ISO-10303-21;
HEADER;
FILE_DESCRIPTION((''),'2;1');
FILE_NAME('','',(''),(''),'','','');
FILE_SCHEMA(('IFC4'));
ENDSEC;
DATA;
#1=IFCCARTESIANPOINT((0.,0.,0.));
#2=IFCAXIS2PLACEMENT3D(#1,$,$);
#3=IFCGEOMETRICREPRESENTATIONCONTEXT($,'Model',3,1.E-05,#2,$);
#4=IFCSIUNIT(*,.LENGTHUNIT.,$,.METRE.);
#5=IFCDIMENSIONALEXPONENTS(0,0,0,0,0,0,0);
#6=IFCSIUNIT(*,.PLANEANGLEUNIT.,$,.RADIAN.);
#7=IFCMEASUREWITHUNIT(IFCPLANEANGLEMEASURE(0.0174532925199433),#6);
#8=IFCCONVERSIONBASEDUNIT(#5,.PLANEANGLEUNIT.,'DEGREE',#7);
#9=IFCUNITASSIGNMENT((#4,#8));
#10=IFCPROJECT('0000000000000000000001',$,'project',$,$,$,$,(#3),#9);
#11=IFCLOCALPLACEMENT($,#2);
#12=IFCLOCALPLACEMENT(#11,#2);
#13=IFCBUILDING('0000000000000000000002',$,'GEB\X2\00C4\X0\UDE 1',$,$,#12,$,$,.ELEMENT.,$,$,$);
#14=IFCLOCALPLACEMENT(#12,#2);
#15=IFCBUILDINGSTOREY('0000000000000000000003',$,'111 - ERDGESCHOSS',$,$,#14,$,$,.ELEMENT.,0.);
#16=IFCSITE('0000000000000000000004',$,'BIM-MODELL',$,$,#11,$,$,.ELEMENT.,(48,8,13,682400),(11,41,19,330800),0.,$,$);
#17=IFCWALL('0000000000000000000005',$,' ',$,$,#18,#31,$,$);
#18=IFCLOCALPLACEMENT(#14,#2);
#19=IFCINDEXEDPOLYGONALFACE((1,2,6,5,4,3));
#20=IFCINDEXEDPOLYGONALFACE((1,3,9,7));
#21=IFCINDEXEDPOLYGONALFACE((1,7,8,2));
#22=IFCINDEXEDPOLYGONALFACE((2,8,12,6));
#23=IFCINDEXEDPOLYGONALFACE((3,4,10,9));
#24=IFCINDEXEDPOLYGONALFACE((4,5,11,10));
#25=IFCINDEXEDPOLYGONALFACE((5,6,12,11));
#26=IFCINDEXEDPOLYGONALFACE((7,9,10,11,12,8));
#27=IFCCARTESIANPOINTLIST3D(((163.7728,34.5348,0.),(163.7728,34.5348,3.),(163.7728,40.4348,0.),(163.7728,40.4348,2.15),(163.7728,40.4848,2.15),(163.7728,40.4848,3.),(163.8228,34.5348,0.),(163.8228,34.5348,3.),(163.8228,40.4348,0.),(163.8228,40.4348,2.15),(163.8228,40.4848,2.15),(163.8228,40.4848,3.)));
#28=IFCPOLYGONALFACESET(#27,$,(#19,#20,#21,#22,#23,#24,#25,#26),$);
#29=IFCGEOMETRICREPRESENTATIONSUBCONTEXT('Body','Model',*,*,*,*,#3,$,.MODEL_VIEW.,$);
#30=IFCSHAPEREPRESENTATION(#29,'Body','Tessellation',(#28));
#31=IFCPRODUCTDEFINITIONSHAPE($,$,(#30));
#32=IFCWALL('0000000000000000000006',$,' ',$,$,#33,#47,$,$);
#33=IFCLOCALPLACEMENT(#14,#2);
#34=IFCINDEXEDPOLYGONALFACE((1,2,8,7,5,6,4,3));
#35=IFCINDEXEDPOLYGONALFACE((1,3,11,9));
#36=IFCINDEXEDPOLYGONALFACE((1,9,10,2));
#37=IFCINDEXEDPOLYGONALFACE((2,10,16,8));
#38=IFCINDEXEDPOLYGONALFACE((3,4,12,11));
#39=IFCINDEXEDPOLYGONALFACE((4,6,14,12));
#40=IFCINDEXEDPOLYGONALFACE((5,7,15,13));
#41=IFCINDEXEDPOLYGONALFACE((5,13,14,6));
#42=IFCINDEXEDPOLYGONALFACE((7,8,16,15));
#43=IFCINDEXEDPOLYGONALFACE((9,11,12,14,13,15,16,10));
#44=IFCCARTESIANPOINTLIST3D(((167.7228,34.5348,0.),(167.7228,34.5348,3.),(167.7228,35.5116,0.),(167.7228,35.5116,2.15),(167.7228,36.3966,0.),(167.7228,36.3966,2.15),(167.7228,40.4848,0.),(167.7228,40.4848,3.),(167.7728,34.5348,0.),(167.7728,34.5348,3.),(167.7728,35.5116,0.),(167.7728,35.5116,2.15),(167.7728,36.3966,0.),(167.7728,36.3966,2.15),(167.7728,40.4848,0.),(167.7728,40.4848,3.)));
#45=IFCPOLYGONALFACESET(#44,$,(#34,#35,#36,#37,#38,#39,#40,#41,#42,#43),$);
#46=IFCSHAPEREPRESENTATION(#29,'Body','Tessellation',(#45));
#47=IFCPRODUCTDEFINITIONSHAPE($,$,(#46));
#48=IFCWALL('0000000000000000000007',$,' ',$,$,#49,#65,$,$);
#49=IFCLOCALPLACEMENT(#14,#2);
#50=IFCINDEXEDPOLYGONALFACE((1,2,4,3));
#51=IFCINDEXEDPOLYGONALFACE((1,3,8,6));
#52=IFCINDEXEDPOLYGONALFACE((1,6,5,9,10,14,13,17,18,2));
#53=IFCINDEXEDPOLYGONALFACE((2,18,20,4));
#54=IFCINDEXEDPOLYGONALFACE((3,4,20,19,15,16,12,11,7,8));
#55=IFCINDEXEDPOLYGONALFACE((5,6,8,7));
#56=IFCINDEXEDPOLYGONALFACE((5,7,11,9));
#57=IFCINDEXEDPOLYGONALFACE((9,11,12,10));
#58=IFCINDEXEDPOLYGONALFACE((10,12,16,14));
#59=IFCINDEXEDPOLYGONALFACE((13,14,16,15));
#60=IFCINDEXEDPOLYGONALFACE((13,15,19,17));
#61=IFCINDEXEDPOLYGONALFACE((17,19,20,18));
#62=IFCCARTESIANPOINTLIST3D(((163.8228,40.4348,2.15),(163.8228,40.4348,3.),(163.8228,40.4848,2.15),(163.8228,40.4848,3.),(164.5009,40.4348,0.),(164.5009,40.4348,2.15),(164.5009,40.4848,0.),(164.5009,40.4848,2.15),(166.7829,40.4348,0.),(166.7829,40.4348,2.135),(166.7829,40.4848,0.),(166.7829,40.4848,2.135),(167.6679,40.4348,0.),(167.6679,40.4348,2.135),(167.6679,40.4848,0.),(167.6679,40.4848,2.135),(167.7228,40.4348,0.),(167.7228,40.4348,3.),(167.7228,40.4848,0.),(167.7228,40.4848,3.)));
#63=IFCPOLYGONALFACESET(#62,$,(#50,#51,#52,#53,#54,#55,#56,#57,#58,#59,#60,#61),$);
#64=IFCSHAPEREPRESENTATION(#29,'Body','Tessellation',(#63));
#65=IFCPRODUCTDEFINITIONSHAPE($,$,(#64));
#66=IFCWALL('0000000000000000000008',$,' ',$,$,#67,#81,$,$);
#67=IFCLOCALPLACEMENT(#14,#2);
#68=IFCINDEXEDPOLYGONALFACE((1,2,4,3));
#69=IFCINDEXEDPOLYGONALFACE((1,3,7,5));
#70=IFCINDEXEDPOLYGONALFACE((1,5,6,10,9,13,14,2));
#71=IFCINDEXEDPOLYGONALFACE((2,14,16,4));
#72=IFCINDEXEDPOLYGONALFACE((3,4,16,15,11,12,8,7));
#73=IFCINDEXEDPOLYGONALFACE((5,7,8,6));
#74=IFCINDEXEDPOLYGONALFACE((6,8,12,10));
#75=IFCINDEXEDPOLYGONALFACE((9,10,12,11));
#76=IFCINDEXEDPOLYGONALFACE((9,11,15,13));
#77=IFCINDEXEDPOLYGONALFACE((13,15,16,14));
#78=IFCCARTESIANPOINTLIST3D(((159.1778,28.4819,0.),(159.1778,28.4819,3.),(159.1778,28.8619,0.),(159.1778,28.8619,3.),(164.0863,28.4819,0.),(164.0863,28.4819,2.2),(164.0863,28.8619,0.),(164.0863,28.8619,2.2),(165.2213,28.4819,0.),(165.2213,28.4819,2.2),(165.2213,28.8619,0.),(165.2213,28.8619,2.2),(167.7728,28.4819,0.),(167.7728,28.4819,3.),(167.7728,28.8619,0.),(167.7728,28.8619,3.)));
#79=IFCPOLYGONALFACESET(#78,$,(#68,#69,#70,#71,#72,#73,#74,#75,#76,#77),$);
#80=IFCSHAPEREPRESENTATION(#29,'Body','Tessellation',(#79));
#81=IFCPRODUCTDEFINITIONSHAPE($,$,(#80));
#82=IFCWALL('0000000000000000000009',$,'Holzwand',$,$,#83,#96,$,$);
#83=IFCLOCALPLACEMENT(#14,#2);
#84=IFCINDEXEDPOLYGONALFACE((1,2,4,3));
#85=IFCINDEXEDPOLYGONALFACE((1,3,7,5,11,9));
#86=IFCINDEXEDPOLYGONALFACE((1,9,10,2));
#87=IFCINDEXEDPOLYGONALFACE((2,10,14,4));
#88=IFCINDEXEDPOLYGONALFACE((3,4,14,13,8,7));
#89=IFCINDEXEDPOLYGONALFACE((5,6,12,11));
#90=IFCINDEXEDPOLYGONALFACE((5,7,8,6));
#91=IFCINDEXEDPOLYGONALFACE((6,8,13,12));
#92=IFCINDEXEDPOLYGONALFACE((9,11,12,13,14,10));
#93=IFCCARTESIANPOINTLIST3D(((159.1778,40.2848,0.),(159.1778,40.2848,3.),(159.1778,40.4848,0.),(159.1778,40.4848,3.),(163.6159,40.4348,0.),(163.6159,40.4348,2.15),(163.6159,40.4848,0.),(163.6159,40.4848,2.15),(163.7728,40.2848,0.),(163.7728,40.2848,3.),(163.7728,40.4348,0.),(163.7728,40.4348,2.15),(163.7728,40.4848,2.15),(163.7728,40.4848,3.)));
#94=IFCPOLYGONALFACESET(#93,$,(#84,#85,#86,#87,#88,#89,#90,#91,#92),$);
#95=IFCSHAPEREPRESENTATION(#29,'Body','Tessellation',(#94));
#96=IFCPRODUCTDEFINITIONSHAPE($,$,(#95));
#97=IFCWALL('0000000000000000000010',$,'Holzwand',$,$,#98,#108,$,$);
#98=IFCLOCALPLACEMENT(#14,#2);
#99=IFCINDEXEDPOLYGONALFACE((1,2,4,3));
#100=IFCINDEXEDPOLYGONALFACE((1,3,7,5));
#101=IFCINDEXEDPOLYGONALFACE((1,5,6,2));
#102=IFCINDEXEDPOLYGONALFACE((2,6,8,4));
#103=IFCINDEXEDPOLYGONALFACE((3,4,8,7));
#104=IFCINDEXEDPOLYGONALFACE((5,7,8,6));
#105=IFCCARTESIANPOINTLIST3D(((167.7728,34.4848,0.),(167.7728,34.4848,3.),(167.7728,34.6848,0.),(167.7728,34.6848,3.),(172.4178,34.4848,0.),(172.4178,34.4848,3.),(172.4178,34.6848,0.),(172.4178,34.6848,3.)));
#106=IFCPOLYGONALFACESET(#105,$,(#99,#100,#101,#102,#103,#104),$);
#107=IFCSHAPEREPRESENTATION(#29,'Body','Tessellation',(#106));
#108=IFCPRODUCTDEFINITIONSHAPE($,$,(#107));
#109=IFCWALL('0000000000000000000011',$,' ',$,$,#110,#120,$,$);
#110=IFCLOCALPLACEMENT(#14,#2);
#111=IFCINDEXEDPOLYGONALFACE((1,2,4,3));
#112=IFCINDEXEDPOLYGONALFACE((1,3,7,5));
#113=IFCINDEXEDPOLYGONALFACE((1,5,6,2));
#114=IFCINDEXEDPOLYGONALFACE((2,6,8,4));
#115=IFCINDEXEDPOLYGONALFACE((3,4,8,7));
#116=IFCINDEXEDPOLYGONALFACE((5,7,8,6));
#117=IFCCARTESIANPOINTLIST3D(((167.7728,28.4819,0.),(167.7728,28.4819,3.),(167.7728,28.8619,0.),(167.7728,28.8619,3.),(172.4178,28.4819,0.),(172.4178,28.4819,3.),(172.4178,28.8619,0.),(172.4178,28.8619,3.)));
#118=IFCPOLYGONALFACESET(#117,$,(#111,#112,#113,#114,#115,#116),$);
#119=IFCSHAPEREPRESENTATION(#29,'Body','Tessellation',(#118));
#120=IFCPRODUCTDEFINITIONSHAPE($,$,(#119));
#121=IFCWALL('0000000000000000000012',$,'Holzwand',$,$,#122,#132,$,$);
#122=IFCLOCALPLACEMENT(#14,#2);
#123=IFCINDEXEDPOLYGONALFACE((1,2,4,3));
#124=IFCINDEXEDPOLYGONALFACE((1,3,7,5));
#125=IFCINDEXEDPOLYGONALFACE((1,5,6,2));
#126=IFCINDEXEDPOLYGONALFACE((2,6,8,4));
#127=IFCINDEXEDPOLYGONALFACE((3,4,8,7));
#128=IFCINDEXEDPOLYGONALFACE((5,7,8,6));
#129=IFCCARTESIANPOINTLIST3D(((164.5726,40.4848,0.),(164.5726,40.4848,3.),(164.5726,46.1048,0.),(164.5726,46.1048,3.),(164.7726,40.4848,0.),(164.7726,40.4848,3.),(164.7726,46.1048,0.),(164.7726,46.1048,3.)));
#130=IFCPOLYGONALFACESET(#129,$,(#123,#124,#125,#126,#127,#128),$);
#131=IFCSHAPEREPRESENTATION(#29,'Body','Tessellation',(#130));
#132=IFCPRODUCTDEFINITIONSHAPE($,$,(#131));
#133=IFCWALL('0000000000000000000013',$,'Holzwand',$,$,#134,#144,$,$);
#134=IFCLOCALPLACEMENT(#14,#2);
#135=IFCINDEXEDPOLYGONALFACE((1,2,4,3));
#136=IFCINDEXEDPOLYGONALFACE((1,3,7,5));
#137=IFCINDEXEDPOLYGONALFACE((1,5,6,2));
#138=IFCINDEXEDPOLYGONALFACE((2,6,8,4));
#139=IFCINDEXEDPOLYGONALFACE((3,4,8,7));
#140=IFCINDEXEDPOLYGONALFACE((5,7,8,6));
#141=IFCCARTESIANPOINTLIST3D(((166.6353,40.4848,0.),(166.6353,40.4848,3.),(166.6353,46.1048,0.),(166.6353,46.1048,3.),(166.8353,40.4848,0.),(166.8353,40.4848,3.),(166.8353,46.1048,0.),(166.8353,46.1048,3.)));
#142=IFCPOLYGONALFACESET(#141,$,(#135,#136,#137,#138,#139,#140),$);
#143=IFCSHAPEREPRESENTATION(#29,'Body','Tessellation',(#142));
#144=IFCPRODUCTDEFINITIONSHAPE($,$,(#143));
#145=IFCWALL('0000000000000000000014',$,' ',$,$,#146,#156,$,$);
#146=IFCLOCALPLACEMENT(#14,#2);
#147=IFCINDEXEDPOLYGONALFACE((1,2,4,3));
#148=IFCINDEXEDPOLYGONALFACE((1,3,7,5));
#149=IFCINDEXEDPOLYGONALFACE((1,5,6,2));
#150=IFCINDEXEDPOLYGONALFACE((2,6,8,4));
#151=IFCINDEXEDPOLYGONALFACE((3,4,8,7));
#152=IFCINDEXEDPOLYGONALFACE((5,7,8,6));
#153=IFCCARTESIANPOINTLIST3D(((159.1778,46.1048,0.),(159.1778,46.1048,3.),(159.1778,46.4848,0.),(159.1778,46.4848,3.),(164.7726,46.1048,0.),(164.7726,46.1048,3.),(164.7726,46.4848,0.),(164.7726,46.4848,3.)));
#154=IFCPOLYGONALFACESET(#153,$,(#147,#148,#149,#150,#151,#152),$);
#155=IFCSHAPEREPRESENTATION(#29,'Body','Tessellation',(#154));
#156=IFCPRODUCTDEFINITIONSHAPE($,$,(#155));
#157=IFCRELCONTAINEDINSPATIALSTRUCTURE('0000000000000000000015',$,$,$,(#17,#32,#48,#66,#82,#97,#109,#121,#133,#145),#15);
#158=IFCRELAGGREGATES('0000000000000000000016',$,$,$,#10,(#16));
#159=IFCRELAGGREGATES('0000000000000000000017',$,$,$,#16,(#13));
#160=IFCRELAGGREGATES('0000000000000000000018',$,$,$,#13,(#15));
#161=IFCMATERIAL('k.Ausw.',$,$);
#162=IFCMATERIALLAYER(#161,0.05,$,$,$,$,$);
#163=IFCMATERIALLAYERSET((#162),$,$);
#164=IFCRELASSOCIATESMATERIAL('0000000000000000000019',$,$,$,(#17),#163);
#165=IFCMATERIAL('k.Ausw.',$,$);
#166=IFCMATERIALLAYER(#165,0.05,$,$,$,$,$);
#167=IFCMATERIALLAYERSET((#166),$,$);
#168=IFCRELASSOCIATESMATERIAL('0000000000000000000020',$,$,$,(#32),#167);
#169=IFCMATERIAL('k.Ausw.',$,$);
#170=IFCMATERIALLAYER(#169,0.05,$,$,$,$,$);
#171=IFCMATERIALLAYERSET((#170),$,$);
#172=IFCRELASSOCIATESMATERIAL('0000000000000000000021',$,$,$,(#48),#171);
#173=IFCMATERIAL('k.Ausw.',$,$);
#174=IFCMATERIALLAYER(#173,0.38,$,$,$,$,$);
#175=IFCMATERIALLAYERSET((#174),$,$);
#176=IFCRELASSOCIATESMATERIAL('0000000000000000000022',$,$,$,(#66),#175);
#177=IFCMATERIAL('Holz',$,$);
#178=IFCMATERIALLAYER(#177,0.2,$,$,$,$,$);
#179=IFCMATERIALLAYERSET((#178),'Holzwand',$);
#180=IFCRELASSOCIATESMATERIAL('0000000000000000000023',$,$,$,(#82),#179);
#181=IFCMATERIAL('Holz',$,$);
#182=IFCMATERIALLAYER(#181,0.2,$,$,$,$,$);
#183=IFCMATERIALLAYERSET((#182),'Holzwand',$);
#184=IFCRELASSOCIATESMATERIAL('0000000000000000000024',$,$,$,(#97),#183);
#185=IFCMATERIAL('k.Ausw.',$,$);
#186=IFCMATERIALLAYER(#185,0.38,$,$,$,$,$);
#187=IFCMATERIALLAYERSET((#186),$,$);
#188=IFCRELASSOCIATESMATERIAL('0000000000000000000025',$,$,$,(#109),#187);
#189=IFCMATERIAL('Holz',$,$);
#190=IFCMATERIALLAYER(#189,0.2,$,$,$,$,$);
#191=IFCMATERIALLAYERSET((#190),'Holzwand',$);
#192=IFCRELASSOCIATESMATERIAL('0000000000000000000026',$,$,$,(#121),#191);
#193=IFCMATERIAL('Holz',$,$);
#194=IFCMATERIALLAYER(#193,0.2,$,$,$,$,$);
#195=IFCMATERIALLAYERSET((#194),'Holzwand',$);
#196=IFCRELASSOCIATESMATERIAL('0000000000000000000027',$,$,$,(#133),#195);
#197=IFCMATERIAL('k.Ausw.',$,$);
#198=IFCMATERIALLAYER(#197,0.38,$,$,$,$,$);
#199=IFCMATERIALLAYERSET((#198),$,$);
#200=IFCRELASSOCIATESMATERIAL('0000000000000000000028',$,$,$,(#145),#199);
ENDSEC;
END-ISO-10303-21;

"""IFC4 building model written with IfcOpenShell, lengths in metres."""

from ifc_helpers import new_model, entity, si_unit, converted_unit, frame, frame_2d, origin, origin_with_axes, place, context, subcontext, project, spatial, polyline, rectangle, outline, extrude, clip, bounded_halfspace, material, layer, layer_set, layer_usage, element, save


model = new_model("IFC4")

# Units and contexts
model_context = context("Model", 3, precision=1e-05, world=origin())
body_context = subcontext(model_context, "Body", "Model", "MODEL_VIEW")
ifc_project = project(units=[si_unit("LENGTHUNIT", "METRE"), converted_unit("PLANEANGLEUNIT", "DEGREE", entity("IfcPlaneAngleMeasure", 0.0174532925199433), si_unit("PLANEANGLEUNIT", "RADIAN"), dimensions=[0, 0, 0, 0, 0, 0, 0])], contexts=[model_context])

# Site, building, storey
site_placement = place(None, origin())
site = spatial("IfcSite", under=ifc_project, at=site_placement, Name="BIM-MODELL", CompositionType="ELEMENT", RefLatitude=(48, 8, 13, 682400), RefLongitude=(11, 41, 19, 330800), RefElevation=0.0)
building_placement = place(site_placement, origin())
building = spatial("IfcBuilding", under=site, at=building_placement, Name="GEBÄUDE 1", CompositionType="ELEMENT")
storey_placement = place(building_placement, origin())
storey = spatial("IfcBuildingStorey", under=building, at=storey_placement, Name="111 - ERDGESCHOSS", CompositionType="ELEMENT", Elevation=0.0)

# Wall
ifc_material_1 = material(Name="k.Ausw.")
ifc_layer_1 = layer(ifc_material_1, 0.05)
ifc_layer_set_1 = layer_set([ifc_layer_1])
ifc_layer_usage_1 = layer_usage(ifc_layer_set_1, "AXIS2", "POSITIVE", 0.0)
wall_1_placement = place(storey_placement, frame((163.7728, 40.4848, 0.0), z_axis=(0.0, 0.0, 1.0), x_axis=(0.0, -1.0, 0.0)))
element("IfcWall", 1, at=wall_1_placement, inside=storey, material=ifc_layer_usage_1, Name=" ", context=body_context, shape_type="Clipping", body=[
    clip(extrude(rectangle(XDim=5.95, YDim=0.05, at=frame_2d((2.975, 0.025), x_axis=(1.0, 0.0))), origin_with_axes(), (0.0, 0.0, 1.0), 3.0), bounded_halfspace(frame((0.025, 0.025, 2.15), z_axis=(0.0, 0.0, 1.0), x_axis=(0.0, 1.0, 0.0)), True, origin_with_axes(), polyline([(0.05, 0.0), (0.05, 0.05), (0.0, 0.05), (0.0, 0.0), (0.05, 0.0)]))),
])

# Wall, opening
ifc_material_2 = material(Name="k.Ausw.")
ifc_layer_2 = layer(ifc_material_2, 0.05)
ifc_layer_set_2 = layer_set([ifc_layer_2])
ifc_layer_usage_2 = layer_usage(ifc_layer_set_2, "AXIS2", "POSITIVE", 0.0)
wall_2_placement = place(storey_placement, frame((167.7728, 34.5348, 0.0), z_axis=(0.0, 0.0, 1.0), x_axis=(0.0, 1.0, 0.0)))
wall_2 = element("IfcWall", 2, at=wall_2_placement, inside=storey, material=ifc_layer_usage_2, Name=" ", context=body_context, shape_type="SweptSolid", body=[
    extrude(rectangle(XDim=5.95, YDim=0.05, at=frame_2d((2.975, 0.025), x_axis=(1.0, 0.0))), origin_with_axes(), (0.0, 0.0, 1.0), 3.0),
])
opening_1_placement = place(wall_2_placement, frame((1.8618, 0.05, -0.15), z_axis=(0.0, -1.0, 0.0), x_axis=(0.0, 0.0, 1.0)))
element("IfcOpeningElement", 3, at=opening_1_placement, cuts=wall_2, ObjectType="Opening", context=body_context, shape_type="SweptSolid", body=[
    extrude(outline(polyline([(0.0, 0.885), (2.3, 0.885), (2.3, 0.0), (0.0, 0.0), (0.0, 0.885)])), origin_with_axes(), (0.0, 0.0, 1.0), 0.05),
])

# Wall, openings
ifc_material_3 = material(Name="k.Ausw.")
ifc_layer_3 = layer(ifc_material_3, 0.05)
ifc_layer_set_3 = layer_set([ifc_layer_3])
ifc_layer_usage_3 = layer_usage(ifc_layer_set_3, "AXIS2", "POSITIVE", 0.0)
wall_3_placement = place(storey_placement, frame((167.7228, 40.4848, 0.0), z_axis=(0.0, 0.0, 1.0), x_axis=(-1.0, 0.0, 0.0)))
wall_3 = element("IfcWall", 4, at=wall_3_placement, inside=storey, material=ifc_layer_usage_3, Name=" ", context=body_context, shape_type="SweptSolid", body=[
    extrude(rectangle(XDim=3.9, YDim=0.05, at=frame_2d((1.95, 0.025), x_axis=(1.0, 0.0))), origin_with_axes(), (0.0, 0.0, 1.0), 3.0),
])
opening_2_placement = place(wall_3_placement, frame((0.9399, 0.05, 0.0), z_axis=(0.0, -1.0, 0.0), x_axis=(0.0, 0.0, 1.0)))
element("IfcOpeningElement", 5, at=opening_2_placement, cuts=wall_3, ObjectType="Opening", context=body_context, shape_type="SweptSolid", body=[
    extrude(outline(polyline([(0.0, 0.885), (2.135, 0.885), (2.135, 0.0), (0.0, 0.0), (0.0, 0.885)])), origin_with_axes(), (0.0, 0.0, 1.0), 0.05),
])
opening_3_placement = place(wall_3_placement, frame((4.1069, 0.05, -0.15), z_axis=(0.0, -1.0, 0.0), x_axis=(0.0, 0.0, 1.0)))
element("IfcOpeningElement", 6, at=opening_3_placement, cuts=wall_3, ObjectType="Opening", context=body_context, shape_type="SweptSolid", body=[
    extrude(outline(polyline([(0.0, 0.885), (2.3, 0.885), (2.3, 0.0), (0.0, 0.0), (0.0, 0.885)])), origin_with_axes(), (0.0, 0.0, 1.0), 0.05),
])

# Wall, opening
ifc_material_4 = material(Name="k.Ausw.")
ifc_layer_4 = layer(ifc_material_4, 0.38)
ifc_layer_set_4 = layer_set([ifc_layer_4])
ifc_layer_usage_4 = layer_usage(ifc_layer_set_4, "AXIS2", "POSITIVE", 0.0)
wall_4_placement = place(storey_placement, frame((159.1778, 28.4819, 0.0), z_axis=(0.0, 0.0, 1.0), x_axis=(1.0, 0.0, 0.0)))
wall_4 = element("IfcWall", 7, at=wall_4_placement, inside=storey, material=ifc_layer_usage_4, Name=" ", context=body_context, shape_type="SweptSolid", body=[
    extrude(rectangle(XDim=8.595, YDim=0.38, at=frame_2d((4.2975, 0.19), x_axis=(1.0, 0.0))), origin_with_axes(), (0.0, 0.0, 1.0), 3.0),
])
opening_4_placement = place(wall_4_placement, frame((4.9085, 0.0, -0.15), z_axis=(0.0, 1.0, 0.0), x_axis=(0.0, 0.0, 1.0)))
element("IfcOpeningElement", 8, at=opening_4_placement, cuts=wall_4, ObjectType="Opening", context=body_context, shape_type="SweptSolid", body=[
    extrude(outline(polyline([(0.0, 1.135), (2.35, 1.135), (2.35, 0.0), (0.0, 0.0), (0.0, 1.135)])), origin_with_axes(), (0.0, 0.0, 1.0), 0.38),
])

# Walls
ifc_material_5 = material(Name="Holz")
ifc_layer_5 = layer(ifc_material_5, 0.2)
ifc_layer_set_5 = layer_set([ifc_layer_5], Name="Holzwand")
ifc_layer_usage_5 = layer_usage(ifc_layer_set_5, "AXIS2", "POSITIVE", 0.0)
wall_5_placement = place(storey_placement, frame((163.7728, 40.4848, 0.0), z_axis=(0.0, 0.0, 1.0), x_axis=(-1.0, 0.0, 0.0)))
element("IfcWall", 9, at=wall_5_placement, inside=storey, material=ifc_layer_usage_5, Name="Holzwand", context=body_context, shape_type="Clipping", body=[
    clip(extrude(rectangle(XDim=4.595, YDim=0.2, at=frame_2d((2.2975, 0.1), x_axis=(1.0, 0.0))), origin_with_axes(), (0.0, 0.0, 1.0), 3.0), bounded_halfspace(frame((0.0784, 0.025, 2.15), z_axis=(0.0, 0.0, 1.0), x_axis=(-1.0, 0.0, 0.0)), True, origin_with_axes(), polyline([(0.1569, 0.05), (0.0, 0.05), (0.0, 0.0), (0.1569, 0.0), (0.1569, 0.05)]))),
])
ifc_material_6 = material(Name="Holz")
ifc_layer_6 = layer(ifc_material_6, 0.2)
ifc_layer_set_6 = layer_set([ifc_layer_6], Name="Holzwand")
ifc_layer_usage_6 = layer_usage(ifc_layer_set_6, "AXIS2", "POSITIVE", 0.0)
wall_6_placement = place(storey_placement, frame((167.7728, 34.4848, 0.0)))
element("IfcWall", 10, at=wall_6_placement, inside=storey, material=ifc_layer_usage_6, Name="Holzwand", context=body_context, shape_type="SweptSolid", body=[
    extrude(rectangle(XDim=4.645, YDim=0.2, at=frame_2d((2.3225, 0.1), x_axis=(1.0, 0.0))), origin_with_axes(), (0.0, 0.0, 1.0), 3.0),
])
ifc_material_7 = material(Name="k.Ausw.")
ifc_layer_7 = layer(ifc_material_7, 0.38)
ifc_layer_set_7 = layer_set([ifc_layer_7])
ifc_layer_usage_7 = layer_usage(ifc_layer_set_7, "AXIS2", "POSITIVE", 0.0)
wall_7_placement = place(storey_placement, frame((167.7728, 28.4819, 0.0), z_axis=(0.0, 0.0, 1.0), x_axis=(1.0, 0.0, 0.0)))
element("IfcWall", 11, at=wall_7_placement, inside=storey, material=ifc_layer_usage_7, Name=" ", context=body_context, shape_type="SweptSolid", body=[
    extrude(rectangle(XDim=4.645, YDim=0.38, at=frame_2d((2.3225, 0.19), x_axis=(1.0, 0.0))), origin_with_axes(), (0.0, 0.0, 1.0), 3.0),
])
ifc_material_8 = material(Name="Holz")
ifc_layer_8 = layer(ifc_material_8, 0.2)
ifc_layer_set_8 = layer_set([ifc_layer_8], Name="Holzwand")
ifc_layer_usage_8 = layer_usage(ifc_layer_set_8, "AXIS2", "POSITIVE", 0.0)
wall_8_placement = place(storey_placement, frame((164.5726, 46.1048, 0.0), z_axis=(0.0, 0.0, 1.0), x_axis=(0.0, -1.0, 0.0)))
element("IfcWall", 12, at=wall_8_placement, inside=storey, material=ifc_layer_usage_8, Name="Holzwand", context=body_context, shape_type="SweptSolid", body=[
    extrude(rectangle(XDim=5.62, YDim=0.2, at=frame_2d((2.81, 0.1), x_axis=(1.0, 0.0))), origin_with_axes(), (0.0, 0.0, 1.0), 3.0),
])
ifc_material_9 = material(Name="Holz")
ifc_layer_9 = layer(ifc_material_9, 0.2)
ifc_layer_set_9 = layer_set([ifc_layer_9], Name="Holzwand")
ifc_layer_usage_9 = layer_usage(ifc_layer_set_9, "AXIS2", "POSITIVE", 0.0)
wall_9_placement = place(storey_placement, frame((166.6353, 46.1048, 0.0), z_axis=(0.0, 0.0, 1.0), x_axis=(0.0, -1.0, 0.0)))
element("IfcWall", 13, at=wall_9_placement, inside=storey, material=ifc_layer_usage_9, Name="Holzwand", context=body_context, shape_type="SweptSolid", body=[
    extrude(rectangle(XDim=5.62, YDim=0.2, at=frame_2d((2.81, 0.1), x_axis=(1.0, 0.0))), origin_with_axes(), (0.0, 0.0, 1.0), 3.0),
])
ifc_material_10 = material(Name="k.Ausw.")
ifc_layer_10 = layer(ifc_material_10, 0.38)
ifc_layer_set_10 = layer_set([ifc_layer_10])
ifc_layer_usage_10 = layer_usage(ifc_layer_set_10, "AXIS2", "POSITIVE", 0.0)
wall_10_placement = place(storey_placement, frame((164.7726, 46.4848, 0.0), z_axis=(0.0, 0.0, 1.0), x_axis=(-1.0, 0.0, 0.0)))
element("IfcWall", 14, at=wall_10_placement, inside=storey, material=ifc_layer_usage_10, Name=" ", context=body_context, shape_type="SweptSolid", body=[
    extrude(rectangle(XDim=5.5948, YDim=0.38, at=frame_2d((2.7974, 0.19), x_axis=(1.0, 0.0))), origin_with_axes(), (0.0, 0.0, 1.0), 3.0),
])

save(model, "model.ifc")
